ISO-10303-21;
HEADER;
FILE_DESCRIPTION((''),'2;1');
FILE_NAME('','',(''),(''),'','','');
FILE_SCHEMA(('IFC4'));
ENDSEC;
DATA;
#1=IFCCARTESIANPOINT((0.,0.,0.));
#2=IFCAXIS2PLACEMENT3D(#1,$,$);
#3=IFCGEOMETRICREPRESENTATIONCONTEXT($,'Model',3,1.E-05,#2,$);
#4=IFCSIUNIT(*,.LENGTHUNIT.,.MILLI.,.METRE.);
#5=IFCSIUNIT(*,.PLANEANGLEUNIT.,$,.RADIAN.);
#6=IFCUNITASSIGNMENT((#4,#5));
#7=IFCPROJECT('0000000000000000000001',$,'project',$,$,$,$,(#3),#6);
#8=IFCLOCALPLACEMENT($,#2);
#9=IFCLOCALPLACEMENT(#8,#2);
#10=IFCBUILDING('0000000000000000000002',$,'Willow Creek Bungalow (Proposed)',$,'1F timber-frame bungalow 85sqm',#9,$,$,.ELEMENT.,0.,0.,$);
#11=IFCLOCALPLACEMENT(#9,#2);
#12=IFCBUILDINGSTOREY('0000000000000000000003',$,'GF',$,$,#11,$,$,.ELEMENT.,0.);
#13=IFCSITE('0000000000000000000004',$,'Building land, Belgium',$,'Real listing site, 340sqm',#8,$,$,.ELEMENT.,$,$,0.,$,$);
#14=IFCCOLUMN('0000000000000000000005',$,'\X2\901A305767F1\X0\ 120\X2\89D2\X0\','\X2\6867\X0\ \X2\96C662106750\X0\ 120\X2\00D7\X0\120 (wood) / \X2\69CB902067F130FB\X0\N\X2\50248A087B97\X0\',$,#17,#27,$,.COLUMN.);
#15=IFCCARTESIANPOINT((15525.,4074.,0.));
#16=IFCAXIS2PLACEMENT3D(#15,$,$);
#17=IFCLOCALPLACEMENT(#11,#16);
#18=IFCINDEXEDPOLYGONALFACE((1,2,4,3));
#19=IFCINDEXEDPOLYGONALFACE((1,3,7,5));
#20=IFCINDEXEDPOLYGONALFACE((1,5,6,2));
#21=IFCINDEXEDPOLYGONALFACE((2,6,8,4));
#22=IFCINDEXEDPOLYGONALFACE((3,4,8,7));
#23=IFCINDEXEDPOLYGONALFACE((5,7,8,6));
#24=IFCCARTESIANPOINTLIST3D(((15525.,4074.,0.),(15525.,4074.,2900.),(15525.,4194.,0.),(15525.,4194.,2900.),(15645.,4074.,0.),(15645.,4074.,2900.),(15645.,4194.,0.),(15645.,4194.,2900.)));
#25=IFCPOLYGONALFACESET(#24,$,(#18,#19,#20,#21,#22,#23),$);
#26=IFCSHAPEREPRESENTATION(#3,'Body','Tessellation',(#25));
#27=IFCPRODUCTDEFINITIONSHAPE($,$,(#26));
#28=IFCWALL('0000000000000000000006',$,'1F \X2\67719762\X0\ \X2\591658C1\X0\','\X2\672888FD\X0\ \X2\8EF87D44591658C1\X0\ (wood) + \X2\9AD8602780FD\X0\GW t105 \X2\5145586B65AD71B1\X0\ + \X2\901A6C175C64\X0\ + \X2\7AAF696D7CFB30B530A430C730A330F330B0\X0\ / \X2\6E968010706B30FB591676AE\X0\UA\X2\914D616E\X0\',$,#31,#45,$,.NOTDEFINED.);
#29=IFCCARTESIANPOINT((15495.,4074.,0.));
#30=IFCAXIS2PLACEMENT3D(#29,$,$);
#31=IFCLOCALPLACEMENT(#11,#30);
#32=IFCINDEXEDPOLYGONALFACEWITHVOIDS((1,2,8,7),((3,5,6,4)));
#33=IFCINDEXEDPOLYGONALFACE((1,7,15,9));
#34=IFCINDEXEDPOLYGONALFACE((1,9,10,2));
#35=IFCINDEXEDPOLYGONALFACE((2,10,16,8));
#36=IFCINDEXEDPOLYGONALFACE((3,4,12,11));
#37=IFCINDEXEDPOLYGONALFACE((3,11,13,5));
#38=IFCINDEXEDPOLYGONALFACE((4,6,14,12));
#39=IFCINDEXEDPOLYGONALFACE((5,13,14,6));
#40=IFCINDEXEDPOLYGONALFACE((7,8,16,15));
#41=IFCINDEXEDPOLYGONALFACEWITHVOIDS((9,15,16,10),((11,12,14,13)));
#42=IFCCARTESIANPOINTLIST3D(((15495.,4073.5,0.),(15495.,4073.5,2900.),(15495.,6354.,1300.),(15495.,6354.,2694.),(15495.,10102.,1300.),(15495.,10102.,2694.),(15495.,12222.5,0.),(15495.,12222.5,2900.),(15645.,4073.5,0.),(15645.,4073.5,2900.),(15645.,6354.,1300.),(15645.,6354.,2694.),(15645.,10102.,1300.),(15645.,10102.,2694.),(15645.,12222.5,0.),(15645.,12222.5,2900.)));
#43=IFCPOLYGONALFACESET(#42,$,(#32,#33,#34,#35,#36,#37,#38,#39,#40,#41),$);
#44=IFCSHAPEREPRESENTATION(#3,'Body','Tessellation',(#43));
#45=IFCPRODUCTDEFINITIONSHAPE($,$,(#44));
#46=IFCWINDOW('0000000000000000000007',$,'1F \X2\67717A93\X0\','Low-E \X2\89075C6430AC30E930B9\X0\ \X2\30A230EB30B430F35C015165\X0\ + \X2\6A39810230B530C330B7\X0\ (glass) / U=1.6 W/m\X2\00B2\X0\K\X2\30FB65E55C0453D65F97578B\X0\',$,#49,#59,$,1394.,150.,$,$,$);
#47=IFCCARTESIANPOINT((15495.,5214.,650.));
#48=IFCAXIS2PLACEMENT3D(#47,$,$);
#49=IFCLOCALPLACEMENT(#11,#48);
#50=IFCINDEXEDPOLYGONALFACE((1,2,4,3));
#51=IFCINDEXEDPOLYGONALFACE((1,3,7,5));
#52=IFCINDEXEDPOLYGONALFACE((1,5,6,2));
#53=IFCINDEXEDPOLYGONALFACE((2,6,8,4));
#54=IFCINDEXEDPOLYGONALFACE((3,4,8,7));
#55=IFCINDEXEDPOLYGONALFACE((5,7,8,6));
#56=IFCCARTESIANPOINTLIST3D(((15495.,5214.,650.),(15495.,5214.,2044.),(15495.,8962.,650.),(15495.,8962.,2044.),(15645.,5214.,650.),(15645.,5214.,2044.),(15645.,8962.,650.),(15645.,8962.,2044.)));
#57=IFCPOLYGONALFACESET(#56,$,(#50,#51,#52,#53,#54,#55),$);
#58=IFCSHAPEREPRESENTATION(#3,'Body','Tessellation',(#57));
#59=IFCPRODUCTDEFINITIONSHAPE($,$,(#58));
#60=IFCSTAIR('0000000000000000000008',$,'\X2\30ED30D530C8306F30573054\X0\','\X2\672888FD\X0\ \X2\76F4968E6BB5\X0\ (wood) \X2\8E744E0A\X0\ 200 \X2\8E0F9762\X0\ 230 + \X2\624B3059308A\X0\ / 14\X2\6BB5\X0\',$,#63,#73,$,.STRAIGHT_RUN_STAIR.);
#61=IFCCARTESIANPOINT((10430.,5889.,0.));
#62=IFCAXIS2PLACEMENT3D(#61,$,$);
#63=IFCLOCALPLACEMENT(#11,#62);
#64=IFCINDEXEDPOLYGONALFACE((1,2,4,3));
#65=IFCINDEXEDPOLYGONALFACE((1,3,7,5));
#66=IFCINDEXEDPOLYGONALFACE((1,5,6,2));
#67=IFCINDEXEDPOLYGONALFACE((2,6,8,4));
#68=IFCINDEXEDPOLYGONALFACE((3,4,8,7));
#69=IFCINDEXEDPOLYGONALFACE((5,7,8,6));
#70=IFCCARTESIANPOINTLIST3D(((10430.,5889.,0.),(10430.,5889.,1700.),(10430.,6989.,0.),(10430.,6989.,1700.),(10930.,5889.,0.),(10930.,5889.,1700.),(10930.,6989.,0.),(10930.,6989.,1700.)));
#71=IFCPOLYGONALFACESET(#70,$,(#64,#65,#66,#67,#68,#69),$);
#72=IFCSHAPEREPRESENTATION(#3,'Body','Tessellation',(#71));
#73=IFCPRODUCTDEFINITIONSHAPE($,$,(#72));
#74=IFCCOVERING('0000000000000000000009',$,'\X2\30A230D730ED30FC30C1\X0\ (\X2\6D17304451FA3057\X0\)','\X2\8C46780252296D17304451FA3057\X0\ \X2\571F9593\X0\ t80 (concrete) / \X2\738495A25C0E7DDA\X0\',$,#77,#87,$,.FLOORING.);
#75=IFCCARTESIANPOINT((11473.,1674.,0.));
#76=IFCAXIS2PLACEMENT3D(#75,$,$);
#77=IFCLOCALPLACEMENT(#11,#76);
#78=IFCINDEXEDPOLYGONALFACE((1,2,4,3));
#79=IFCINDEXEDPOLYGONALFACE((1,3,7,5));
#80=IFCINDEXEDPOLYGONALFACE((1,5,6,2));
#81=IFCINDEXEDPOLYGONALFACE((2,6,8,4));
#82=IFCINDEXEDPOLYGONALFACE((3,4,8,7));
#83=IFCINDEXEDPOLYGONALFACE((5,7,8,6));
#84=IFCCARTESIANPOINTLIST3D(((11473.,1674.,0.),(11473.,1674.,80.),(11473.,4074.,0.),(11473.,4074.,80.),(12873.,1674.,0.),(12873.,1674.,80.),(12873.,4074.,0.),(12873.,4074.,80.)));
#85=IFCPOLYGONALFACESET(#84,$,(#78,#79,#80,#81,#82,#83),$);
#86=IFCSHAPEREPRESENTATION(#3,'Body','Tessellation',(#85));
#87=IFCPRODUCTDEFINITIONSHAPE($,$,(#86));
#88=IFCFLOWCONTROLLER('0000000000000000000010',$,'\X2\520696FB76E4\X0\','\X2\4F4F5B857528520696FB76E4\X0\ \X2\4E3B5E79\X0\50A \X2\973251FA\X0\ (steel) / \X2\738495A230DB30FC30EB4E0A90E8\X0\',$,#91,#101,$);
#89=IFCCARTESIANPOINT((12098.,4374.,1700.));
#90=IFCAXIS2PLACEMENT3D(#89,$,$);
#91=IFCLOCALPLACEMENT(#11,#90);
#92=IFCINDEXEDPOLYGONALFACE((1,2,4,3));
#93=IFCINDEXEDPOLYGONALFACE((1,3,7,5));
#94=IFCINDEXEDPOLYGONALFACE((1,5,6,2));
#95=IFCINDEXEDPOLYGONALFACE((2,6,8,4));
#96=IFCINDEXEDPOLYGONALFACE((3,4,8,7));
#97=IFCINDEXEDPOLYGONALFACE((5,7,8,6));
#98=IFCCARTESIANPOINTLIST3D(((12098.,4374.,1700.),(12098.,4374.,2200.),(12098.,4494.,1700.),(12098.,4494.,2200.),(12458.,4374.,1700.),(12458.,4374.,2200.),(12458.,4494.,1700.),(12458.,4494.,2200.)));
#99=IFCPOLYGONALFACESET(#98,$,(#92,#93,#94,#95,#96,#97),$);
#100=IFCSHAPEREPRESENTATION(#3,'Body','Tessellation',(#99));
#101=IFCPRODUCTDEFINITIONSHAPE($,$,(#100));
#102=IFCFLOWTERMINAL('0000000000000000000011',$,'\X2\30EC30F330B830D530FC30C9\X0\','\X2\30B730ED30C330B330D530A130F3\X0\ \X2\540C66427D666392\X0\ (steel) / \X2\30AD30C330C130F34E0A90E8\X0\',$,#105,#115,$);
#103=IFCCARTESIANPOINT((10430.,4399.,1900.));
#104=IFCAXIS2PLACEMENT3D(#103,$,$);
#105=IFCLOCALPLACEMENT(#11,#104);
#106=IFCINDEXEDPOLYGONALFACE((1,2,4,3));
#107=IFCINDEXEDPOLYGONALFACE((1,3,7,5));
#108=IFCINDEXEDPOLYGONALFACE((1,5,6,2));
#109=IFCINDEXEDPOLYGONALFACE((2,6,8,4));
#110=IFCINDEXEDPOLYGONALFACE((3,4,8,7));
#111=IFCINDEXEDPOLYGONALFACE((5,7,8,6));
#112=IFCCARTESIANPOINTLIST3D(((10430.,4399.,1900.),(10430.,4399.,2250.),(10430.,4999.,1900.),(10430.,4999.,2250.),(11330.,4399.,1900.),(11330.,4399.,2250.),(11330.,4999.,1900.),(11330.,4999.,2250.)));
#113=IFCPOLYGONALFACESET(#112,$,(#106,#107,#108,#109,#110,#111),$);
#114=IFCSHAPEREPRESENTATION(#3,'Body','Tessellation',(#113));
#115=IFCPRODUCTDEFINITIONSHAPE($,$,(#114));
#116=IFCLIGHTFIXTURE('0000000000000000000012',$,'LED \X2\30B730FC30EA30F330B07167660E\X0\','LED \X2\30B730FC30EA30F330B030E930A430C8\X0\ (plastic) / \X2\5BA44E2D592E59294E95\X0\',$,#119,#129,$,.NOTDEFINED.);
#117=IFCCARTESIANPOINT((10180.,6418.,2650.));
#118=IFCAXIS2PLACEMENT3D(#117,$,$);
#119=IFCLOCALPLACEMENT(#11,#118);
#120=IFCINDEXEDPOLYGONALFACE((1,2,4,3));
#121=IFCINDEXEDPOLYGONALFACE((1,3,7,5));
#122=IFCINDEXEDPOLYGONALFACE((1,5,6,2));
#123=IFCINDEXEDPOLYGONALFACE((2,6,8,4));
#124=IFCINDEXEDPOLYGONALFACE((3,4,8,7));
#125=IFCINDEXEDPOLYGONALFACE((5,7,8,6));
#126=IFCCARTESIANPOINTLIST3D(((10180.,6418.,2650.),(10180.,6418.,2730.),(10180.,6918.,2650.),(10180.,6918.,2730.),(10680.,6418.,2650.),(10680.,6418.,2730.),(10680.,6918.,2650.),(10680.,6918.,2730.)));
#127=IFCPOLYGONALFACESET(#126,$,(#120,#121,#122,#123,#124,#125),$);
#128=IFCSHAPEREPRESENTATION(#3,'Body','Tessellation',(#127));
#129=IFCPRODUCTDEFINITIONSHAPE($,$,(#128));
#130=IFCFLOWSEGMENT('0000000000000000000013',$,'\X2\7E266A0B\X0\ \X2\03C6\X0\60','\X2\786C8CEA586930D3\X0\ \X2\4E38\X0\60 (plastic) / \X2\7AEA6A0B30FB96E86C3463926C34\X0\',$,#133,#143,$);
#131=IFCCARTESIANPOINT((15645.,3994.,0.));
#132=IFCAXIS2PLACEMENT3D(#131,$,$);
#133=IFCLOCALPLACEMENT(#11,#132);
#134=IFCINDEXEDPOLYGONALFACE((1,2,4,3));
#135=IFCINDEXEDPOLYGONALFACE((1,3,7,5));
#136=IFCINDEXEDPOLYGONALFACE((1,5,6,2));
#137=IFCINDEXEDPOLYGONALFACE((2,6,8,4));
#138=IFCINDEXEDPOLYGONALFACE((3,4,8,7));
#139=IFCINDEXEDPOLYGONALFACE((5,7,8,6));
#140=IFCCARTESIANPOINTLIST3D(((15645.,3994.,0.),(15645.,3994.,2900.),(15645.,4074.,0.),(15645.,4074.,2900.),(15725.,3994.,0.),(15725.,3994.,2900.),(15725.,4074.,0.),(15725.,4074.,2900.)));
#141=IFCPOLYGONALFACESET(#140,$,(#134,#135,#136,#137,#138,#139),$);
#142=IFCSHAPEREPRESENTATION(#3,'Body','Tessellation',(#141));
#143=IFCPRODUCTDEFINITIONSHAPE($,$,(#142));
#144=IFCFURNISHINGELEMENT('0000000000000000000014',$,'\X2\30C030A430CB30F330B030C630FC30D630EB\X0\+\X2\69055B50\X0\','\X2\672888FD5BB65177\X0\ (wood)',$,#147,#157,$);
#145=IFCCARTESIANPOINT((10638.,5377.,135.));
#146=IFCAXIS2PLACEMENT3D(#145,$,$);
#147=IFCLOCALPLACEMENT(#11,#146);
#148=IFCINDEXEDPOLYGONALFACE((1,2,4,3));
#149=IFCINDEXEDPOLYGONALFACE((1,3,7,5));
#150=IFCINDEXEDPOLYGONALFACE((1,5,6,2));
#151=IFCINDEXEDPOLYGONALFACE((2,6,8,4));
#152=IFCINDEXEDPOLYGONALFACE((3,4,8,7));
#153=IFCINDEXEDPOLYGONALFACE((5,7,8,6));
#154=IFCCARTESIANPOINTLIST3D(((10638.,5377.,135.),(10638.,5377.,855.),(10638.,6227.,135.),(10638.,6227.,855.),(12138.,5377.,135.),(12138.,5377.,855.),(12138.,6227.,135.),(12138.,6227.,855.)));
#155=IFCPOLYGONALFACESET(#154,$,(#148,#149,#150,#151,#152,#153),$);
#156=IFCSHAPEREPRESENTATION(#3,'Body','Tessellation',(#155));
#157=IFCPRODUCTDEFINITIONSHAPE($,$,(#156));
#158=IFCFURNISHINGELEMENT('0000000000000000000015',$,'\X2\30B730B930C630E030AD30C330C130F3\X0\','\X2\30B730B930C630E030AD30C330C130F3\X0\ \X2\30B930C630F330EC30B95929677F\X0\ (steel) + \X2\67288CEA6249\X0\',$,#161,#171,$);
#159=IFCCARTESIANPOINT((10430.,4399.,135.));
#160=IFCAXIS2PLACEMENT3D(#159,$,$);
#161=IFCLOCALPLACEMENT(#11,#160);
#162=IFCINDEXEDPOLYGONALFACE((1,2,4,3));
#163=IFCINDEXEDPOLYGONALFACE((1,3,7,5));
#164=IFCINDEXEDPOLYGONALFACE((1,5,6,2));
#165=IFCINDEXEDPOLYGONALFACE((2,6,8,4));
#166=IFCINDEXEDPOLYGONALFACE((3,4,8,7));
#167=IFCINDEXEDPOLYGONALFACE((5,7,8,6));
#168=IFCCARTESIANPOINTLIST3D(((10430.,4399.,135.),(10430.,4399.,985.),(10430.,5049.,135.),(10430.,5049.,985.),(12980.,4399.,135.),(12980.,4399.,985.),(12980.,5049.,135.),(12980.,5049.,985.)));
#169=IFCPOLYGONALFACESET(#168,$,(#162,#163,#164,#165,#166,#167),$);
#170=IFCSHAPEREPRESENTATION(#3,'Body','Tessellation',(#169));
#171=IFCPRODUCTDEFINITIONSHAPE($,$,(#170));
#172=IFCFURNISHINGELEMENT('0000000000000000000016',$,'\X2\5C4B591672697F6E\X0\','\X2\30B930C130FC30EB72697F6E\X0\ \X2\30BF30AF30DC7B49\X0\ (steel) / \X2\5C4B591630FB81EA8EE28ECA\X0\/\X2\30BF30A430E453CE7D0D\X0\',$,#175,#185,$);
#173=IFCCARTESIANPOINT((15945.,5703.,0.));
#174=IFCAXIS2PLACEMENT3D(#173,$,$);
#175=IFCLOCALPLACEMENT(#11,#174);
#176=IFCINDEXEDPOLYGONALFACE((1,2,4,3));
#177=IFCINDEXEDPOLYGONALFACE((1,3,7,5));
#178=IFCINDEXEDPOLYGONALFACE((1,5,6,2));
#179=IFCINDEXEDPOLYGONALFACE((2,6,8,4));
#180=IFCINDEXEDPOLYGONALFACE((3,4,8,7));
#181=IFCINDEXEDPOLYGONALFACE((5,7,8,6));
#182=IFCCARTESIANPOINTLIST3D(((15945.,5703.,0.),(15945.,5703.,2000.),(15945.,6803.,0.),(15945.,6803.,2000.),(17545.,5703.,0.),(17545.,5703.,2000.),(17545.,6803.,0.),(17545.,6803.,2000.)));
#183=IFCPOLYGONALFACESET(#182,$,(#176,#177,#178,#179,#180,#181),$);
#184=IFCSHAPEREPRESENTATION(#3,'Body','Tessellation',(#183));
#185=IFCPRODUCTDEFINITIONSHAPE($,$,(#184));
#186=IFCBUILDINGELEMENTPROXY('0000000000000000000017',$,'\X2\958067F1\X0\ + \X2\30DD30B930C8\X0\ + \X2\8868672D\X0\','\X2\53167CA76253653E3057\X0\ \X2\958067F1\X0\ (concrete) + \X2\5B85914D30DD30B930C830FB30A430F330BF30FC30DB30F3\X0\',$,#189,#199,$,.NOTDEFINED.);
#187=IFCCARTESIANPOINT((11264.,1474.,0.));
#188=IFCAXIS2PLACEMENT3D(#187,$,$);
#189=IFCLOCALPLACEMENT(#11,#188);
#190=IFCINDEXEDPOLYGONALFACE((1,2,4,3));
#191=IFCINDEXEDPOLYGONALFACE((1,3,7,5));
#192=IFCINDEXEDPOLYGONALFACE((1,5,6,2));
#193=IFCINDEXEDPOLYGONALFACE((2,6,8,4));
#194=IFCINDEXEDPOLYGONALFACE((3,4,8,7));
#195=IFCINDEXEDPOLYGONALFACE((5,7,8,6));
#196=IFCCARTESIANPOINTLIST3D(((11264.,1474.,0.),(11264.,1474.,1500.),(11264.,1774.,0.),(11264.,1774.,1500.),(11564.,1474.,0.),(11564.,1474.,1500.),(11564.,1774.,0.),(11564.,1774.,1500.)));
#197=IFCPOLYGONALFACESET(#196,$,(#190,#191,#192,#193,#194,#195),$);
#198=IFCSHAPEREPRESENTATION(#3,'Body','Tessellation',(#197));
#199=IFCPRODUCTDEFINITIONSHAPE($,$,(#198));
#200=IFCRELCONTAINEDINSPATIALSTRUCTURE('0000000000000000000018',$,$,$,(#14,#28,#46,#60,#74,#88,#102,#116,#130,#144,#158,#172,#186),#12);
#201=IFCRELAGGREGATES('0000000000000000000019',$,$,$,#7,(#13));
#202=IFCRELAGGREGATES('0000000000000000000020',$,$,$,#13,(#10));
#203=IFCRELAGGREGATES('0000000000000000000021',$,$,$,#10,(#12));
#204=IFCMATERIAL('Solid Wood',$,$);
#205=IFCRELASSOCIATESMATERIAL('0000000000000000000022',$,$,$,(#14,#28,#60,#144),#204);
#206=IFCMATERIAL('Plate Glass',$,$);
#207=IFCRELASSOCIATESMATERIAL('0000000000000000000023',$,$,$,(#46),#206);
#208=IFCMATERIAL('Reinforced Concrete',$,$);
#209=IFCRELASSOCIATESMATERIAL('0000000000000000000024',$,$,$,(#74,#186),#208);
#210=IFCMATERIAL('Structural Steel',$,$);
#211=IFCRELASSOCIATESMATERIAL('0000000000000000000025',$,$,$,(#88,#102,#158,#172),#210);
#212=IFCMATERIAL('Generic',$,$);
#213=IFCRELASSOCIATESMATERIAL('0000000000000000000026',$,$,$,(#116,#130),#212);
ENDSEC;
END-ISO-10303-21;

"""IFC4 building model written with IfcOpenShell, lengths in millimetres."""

from ifc_helpers import new_model, si_unit, frame, frame_2d, origin, place, context, project, spatial, rectangle, extrude, material, element, fill, save


model = new_model("IFC4")

# Units and contexts
model_context = context("Model", 3, precision=1e-05, world=origin())
ifc_project = project(units=[si_unit("LENGTHUNIT", "METRE", prefix="MILLI"), si_unit("PLANEANGLEUNIT", "RADIAN")], contexts=[model_context])

# Site, building, storey
site_placement = place(None, origin())
site = spatial("IfcSite", under=ifc_project, at=site_placement, Name="Building land, Belgium", ObjectType="Real listing site, 340sqm", CompositionType="ELEMENT", RefElevation=0.0)
building_placement = place(site_placement, origin())
building = spatial("IfcBuilding", under=site, at=building_placement, Name="Willow Creek Bungalow (Proposed)", ObjectType="1F timber-frame bungalow 85sqm", CompositionType="ELEMENT", ElevationOfRefHeight=0.0, ElevationOfTerrain=0.0)
storey_placement = place(building_placement, origin())
storey = spatial("IfcBuildingStorey", under=building, at=storey_placement, Name="GF", CompositionType="ELEMENT", Elevation=0.0)

# Column
ifc_material_1 = material(Name="Solid Wood")
column_1_placement = place(storey_placement, frame((15525.0, 4074.0, 0.0)))
element("IfcColumn", 1, at=column_1_placement, inside=storey, material=ifc_material_1, Name="通し柱 120角", Description="桧 集成材 120×120 (wood) / 構造柱・N値計算", PredefinedType="COLUMN", context=model_context, shape_type="SweptSolid", body=[
    extrude(rectangle(XDim=120.0, YDim=120.0, at=frame_2d((60.0, 60.0))), frame((15525.0, 4074.0, 0.0)), (0.0, 0.0, 1.0), 2900.0),
])

# Wall, opening, window
wall_1_placement = place(storey_placement, frame((15495.0, 4074.0, 0.0)))
wall_1 = element("IfcWall", 2, at=wall_1_placement, inside=storey, material=ifc_material_1, Name="1F 東面 外壁", Description="木製 軸組外壁 (wood) + 高性能GW t105 充填断熱 + 通気層 + 窯業系サイディング / 準耐火・外皮UA配慮", PredefinedType="NOTDEFINED", context=model_context, shape_type="SweptSolid", body=[
    extrude(rectangle(XDim=150.0, YDim=8149.0, at=frame_2d((75.0, 4074.0))), frame((15495.0, 4074.0, 0.0)), (0.0, 0.0, 1.0), 2900.0),
])
opening_placement = place(storey_placement, frame((15495.0, 5214.0, 650.0)))
opening = element("IfcOpeningElement", 3, at=opening_placement, cuts=wall_1, PredefinedType="NOTDEFINED", context=model_context, shape_type="SweptSolid", body=[
    extrude(rectangle(XDim=150.0, YDim=3748.0, at=frame_2d((75.0, 1874.0))), frame((15495.0, 5214.0, 650.0)), (0.0, 0.0, 1.0), 1394.0),
])
ifc_material_2 = material(Name="Plate Glass")
window_placement = place(storey_placement, frame((15495.0, 5214.0, 650.0)))
window = element("IfcWindow", 4, at=window_placement, inside=storey, material=ifc_material_2, Name="1F 東窓", Description="Low-E 複層ガラス アルゴン封入 + 樹脂サッシ (glass) / U=1.6 W/m²K・日射取得型", OverallHeight=1394.0, OverallWidth=150.0, context=model_context, shape_type="SweptSolid", body=[
    extrude(rectangle(XDim=150.0, YDim=3748.0, at=frame_2d((75.0, 1874.0))), frame((15495.0, 5214.0, 650.0)), (0.0, 0.0, 1.0), 1394.0),
])
fill(opening, window)

# Stair
stair_placement = place(storey_placement, frame((10430.0, 5889.0, 0.0)))
element("IfcStair", 5, at=stair_placement, inside=storey, material=ifc_material_1, Name="ロフトはしご", Description="木製 直階段 (wood) 蹴上 200 踏面 230 + 手すり / 14段", PredefinedType="STRAIGHT_RUN_STAIR", context=model_context, shape_type="SweptSolid", body=[
    extrude(rectangle(XDim=500.0, YDim=1100.0, at=frame_2d((250.0, 550.0))), frame((10430.0, 5889.0, 0.0)), (0.0, 0.0, 1.0), 1700.0),
])

# Covering
ifc_material_3 = material(Name="Reinforced Concrete")
covering_placement = place(storey_placement, frame((11473.0, 1674.0, 0.0)))
element("IfcCovering", 6, at=covering_placement, inside=storey, material=ifc_material_3, Name="アプローチ (洗い出し)", Description="豆砂利洗い出し 土間 t80 (concrete) / 玄関導線", PredefinedType="FLOORING", context=model_context, shape_type="SweptSolid", body=[
    extrude(rectangle(XDim=1400.0, YDim=2400.0, at=frame_2d((700.0, 1200.0))), frame((11473.0, 1674.0, 0.0)), (0.0, 0.0, 1.0), 80.0),
])

# Flow controller
ifc_material_4 = material(Name="Structural Steel")
flow_controller_placement = place(storey_placement, frame((12098.0, 4374.0, 1700.0)))
element("IfcFlowController", 7, at=flow_controller_placement, inside=storey, material=ifc_material_4, Name="分電盤", Description="住宅用分電盤 主幹50A 露出 (steel) / 玄関ホール上部", context=model_context, shape_type="SweptSolid", body=[
    extrude(rectangle(XDim=360.0, YDim=120.0, at=frame_2d((180.0, 60.0))), frame((12098.0, 4374.0, 1700.0)), (0.0, 0.0, 1.0), 500.0),
])

# Flow terminal
flow_terminal_placement = place(storey_placement, frame((10430.0, 4399.0, 1900.0)))
element("IfcFlowTerminal", 8, at=flow_terminal_placement, inside=storey, material=ifc_material_4, Name="レンジフード", Description="シロッコファン 同時給排 (steel) / キッチン上部", context=model_context, shape_type="SweptSolid", body=[
    extrude(rectangle(XDim=900.0, YDim=600.0, at=frame_2d((450.0, 300.0))), frame((10430.0, 4399.0, 1900.0)), (0.0, 0.0, 1.0), 350.0),
])

# Light fixture
ifc_material_5 = material(Name="Generic")
light_fixture_placement = place(storey_placement, frame((10180.0, 6418.0, 2650.0)))
element("IfcLightFixture", 9, at=light_fixture_placement, inside=storey, material=ifc_material_5, Name="LED シーリング照明", Description="LED シーリングライト (plastic) / 室中央天井", PredefinedType="NOTDEFINED", context=model_context, shape_type="SweptSolid", body=[
    extrude(rectangle(XDim=500.0, YDim=500.0, at=frame_2d((250.0, 250.0))), frame((10180.0, 6418.0, 2650.0)), (0.0, 0.0, 1.0), 80.0),
])

# Flow segment
flow_segment_placement = place(storey_placement, frame((15645.0, 3994.0, 0.0)))
element("IfcFlowSegment", 10, at=flow_segment_placement, inside=storey, material=ifc_material_5, Name="縦樋 φ60", Description="硬質塩ビ 丸60 (plastic) / 竪樋・雨水排水", context=model_context, shape_type="SweptSolid", body=[
    extrude(rectangle(XDim=80.0, YDim=80.0, at=frame_2d((40.0, 40.0))), frame((15645.0, 3994.0, 0.0)), (0.0, 0.0, 1.0), 2900.0),
])

# Furnishing elements
furnishing_1_placement = place(storey_placement, frame((10638.0, 5377.0, 135.0)))
element("IfcFurnishingElement", 11, at=furnishing_1_placement, inside=storey, material=ifc_material_1, Name="ダイニングテーブル+椅子", Description="木製家具 (wood)", context=model_context, shape_type="SweptSolid", body=[
    extrude(rectangle(XDim=1500.0, YDim=850.0, at=frame_2d((750.0, 425.0))), frame((10638.0, 5377.0, 135.0)), (0.0, 0.0, 1.0), 720.0),
])
furnishing_2_placement = place(storey_placement, frame((10430.0, 4399.0, 135.0)))
element("IfcFurnishingElement", 12, at=furnishing_2_placement, inside=storey, material=ifc_material_4, Name="システムキッチン", Description="システムキッチン ステンレス天板 (steel) + 木質扉", context=model_context, shape_type="SweptSolid", body=[
    extrude(rectangle(XDim=2550.0, YDim=650.0, at=frame_2d((1275.0, 325.0))), frame((10430.0, 4399.0, 135.0)), (0.0, 0.0, 1.0), 850.0),
])
furnishing_3_placement = place(storey_placement, frame((15945.0, 5703.0, 0.0)))
element("IfcFurnishingElement", 13, at=furnishing_3_placement, inside=storey, material=ifc_material_4, Name="屋外物置", Description="スチール物置 タクボ等 (steel) / 屋外・自転車/タイヤ収納", context=model_context, shape_type="SweptSolid", body=[
    extrude(rectangle(XDim=1600.0, YDim=1100.0, at=frame_2d((800.0, 550.0))), frame((15945.0, 5703.0, 0.0)), (0.0, 0.0, 1.0), 2000.0),
])

# Building element proxy
proxy_placement = place(storey_placement, frame((11264.0, 1474.0, 0.0)))
element("IfcBuildingElementProxy", 14, at=proxy_placement, inside=storey, material=ifc_material_3, Name="門柱 + ポスト + 表札", Description="化粧打放し 門柱 (concrete) + 宅配ポスト・インターホン", PredefinedType="NOTDEFINED", context=model_context, shape_type="SweptSolid", body=[
    extrude(rectangle(XDim=300.0, YDim=300.0, at=frame_2d((150.0, 150.0))), frame((11264.0, 1474.0, 0.0)), (0.0, 0.0, 1.0), 1500.0),
])

save(model, "model.ifc")
